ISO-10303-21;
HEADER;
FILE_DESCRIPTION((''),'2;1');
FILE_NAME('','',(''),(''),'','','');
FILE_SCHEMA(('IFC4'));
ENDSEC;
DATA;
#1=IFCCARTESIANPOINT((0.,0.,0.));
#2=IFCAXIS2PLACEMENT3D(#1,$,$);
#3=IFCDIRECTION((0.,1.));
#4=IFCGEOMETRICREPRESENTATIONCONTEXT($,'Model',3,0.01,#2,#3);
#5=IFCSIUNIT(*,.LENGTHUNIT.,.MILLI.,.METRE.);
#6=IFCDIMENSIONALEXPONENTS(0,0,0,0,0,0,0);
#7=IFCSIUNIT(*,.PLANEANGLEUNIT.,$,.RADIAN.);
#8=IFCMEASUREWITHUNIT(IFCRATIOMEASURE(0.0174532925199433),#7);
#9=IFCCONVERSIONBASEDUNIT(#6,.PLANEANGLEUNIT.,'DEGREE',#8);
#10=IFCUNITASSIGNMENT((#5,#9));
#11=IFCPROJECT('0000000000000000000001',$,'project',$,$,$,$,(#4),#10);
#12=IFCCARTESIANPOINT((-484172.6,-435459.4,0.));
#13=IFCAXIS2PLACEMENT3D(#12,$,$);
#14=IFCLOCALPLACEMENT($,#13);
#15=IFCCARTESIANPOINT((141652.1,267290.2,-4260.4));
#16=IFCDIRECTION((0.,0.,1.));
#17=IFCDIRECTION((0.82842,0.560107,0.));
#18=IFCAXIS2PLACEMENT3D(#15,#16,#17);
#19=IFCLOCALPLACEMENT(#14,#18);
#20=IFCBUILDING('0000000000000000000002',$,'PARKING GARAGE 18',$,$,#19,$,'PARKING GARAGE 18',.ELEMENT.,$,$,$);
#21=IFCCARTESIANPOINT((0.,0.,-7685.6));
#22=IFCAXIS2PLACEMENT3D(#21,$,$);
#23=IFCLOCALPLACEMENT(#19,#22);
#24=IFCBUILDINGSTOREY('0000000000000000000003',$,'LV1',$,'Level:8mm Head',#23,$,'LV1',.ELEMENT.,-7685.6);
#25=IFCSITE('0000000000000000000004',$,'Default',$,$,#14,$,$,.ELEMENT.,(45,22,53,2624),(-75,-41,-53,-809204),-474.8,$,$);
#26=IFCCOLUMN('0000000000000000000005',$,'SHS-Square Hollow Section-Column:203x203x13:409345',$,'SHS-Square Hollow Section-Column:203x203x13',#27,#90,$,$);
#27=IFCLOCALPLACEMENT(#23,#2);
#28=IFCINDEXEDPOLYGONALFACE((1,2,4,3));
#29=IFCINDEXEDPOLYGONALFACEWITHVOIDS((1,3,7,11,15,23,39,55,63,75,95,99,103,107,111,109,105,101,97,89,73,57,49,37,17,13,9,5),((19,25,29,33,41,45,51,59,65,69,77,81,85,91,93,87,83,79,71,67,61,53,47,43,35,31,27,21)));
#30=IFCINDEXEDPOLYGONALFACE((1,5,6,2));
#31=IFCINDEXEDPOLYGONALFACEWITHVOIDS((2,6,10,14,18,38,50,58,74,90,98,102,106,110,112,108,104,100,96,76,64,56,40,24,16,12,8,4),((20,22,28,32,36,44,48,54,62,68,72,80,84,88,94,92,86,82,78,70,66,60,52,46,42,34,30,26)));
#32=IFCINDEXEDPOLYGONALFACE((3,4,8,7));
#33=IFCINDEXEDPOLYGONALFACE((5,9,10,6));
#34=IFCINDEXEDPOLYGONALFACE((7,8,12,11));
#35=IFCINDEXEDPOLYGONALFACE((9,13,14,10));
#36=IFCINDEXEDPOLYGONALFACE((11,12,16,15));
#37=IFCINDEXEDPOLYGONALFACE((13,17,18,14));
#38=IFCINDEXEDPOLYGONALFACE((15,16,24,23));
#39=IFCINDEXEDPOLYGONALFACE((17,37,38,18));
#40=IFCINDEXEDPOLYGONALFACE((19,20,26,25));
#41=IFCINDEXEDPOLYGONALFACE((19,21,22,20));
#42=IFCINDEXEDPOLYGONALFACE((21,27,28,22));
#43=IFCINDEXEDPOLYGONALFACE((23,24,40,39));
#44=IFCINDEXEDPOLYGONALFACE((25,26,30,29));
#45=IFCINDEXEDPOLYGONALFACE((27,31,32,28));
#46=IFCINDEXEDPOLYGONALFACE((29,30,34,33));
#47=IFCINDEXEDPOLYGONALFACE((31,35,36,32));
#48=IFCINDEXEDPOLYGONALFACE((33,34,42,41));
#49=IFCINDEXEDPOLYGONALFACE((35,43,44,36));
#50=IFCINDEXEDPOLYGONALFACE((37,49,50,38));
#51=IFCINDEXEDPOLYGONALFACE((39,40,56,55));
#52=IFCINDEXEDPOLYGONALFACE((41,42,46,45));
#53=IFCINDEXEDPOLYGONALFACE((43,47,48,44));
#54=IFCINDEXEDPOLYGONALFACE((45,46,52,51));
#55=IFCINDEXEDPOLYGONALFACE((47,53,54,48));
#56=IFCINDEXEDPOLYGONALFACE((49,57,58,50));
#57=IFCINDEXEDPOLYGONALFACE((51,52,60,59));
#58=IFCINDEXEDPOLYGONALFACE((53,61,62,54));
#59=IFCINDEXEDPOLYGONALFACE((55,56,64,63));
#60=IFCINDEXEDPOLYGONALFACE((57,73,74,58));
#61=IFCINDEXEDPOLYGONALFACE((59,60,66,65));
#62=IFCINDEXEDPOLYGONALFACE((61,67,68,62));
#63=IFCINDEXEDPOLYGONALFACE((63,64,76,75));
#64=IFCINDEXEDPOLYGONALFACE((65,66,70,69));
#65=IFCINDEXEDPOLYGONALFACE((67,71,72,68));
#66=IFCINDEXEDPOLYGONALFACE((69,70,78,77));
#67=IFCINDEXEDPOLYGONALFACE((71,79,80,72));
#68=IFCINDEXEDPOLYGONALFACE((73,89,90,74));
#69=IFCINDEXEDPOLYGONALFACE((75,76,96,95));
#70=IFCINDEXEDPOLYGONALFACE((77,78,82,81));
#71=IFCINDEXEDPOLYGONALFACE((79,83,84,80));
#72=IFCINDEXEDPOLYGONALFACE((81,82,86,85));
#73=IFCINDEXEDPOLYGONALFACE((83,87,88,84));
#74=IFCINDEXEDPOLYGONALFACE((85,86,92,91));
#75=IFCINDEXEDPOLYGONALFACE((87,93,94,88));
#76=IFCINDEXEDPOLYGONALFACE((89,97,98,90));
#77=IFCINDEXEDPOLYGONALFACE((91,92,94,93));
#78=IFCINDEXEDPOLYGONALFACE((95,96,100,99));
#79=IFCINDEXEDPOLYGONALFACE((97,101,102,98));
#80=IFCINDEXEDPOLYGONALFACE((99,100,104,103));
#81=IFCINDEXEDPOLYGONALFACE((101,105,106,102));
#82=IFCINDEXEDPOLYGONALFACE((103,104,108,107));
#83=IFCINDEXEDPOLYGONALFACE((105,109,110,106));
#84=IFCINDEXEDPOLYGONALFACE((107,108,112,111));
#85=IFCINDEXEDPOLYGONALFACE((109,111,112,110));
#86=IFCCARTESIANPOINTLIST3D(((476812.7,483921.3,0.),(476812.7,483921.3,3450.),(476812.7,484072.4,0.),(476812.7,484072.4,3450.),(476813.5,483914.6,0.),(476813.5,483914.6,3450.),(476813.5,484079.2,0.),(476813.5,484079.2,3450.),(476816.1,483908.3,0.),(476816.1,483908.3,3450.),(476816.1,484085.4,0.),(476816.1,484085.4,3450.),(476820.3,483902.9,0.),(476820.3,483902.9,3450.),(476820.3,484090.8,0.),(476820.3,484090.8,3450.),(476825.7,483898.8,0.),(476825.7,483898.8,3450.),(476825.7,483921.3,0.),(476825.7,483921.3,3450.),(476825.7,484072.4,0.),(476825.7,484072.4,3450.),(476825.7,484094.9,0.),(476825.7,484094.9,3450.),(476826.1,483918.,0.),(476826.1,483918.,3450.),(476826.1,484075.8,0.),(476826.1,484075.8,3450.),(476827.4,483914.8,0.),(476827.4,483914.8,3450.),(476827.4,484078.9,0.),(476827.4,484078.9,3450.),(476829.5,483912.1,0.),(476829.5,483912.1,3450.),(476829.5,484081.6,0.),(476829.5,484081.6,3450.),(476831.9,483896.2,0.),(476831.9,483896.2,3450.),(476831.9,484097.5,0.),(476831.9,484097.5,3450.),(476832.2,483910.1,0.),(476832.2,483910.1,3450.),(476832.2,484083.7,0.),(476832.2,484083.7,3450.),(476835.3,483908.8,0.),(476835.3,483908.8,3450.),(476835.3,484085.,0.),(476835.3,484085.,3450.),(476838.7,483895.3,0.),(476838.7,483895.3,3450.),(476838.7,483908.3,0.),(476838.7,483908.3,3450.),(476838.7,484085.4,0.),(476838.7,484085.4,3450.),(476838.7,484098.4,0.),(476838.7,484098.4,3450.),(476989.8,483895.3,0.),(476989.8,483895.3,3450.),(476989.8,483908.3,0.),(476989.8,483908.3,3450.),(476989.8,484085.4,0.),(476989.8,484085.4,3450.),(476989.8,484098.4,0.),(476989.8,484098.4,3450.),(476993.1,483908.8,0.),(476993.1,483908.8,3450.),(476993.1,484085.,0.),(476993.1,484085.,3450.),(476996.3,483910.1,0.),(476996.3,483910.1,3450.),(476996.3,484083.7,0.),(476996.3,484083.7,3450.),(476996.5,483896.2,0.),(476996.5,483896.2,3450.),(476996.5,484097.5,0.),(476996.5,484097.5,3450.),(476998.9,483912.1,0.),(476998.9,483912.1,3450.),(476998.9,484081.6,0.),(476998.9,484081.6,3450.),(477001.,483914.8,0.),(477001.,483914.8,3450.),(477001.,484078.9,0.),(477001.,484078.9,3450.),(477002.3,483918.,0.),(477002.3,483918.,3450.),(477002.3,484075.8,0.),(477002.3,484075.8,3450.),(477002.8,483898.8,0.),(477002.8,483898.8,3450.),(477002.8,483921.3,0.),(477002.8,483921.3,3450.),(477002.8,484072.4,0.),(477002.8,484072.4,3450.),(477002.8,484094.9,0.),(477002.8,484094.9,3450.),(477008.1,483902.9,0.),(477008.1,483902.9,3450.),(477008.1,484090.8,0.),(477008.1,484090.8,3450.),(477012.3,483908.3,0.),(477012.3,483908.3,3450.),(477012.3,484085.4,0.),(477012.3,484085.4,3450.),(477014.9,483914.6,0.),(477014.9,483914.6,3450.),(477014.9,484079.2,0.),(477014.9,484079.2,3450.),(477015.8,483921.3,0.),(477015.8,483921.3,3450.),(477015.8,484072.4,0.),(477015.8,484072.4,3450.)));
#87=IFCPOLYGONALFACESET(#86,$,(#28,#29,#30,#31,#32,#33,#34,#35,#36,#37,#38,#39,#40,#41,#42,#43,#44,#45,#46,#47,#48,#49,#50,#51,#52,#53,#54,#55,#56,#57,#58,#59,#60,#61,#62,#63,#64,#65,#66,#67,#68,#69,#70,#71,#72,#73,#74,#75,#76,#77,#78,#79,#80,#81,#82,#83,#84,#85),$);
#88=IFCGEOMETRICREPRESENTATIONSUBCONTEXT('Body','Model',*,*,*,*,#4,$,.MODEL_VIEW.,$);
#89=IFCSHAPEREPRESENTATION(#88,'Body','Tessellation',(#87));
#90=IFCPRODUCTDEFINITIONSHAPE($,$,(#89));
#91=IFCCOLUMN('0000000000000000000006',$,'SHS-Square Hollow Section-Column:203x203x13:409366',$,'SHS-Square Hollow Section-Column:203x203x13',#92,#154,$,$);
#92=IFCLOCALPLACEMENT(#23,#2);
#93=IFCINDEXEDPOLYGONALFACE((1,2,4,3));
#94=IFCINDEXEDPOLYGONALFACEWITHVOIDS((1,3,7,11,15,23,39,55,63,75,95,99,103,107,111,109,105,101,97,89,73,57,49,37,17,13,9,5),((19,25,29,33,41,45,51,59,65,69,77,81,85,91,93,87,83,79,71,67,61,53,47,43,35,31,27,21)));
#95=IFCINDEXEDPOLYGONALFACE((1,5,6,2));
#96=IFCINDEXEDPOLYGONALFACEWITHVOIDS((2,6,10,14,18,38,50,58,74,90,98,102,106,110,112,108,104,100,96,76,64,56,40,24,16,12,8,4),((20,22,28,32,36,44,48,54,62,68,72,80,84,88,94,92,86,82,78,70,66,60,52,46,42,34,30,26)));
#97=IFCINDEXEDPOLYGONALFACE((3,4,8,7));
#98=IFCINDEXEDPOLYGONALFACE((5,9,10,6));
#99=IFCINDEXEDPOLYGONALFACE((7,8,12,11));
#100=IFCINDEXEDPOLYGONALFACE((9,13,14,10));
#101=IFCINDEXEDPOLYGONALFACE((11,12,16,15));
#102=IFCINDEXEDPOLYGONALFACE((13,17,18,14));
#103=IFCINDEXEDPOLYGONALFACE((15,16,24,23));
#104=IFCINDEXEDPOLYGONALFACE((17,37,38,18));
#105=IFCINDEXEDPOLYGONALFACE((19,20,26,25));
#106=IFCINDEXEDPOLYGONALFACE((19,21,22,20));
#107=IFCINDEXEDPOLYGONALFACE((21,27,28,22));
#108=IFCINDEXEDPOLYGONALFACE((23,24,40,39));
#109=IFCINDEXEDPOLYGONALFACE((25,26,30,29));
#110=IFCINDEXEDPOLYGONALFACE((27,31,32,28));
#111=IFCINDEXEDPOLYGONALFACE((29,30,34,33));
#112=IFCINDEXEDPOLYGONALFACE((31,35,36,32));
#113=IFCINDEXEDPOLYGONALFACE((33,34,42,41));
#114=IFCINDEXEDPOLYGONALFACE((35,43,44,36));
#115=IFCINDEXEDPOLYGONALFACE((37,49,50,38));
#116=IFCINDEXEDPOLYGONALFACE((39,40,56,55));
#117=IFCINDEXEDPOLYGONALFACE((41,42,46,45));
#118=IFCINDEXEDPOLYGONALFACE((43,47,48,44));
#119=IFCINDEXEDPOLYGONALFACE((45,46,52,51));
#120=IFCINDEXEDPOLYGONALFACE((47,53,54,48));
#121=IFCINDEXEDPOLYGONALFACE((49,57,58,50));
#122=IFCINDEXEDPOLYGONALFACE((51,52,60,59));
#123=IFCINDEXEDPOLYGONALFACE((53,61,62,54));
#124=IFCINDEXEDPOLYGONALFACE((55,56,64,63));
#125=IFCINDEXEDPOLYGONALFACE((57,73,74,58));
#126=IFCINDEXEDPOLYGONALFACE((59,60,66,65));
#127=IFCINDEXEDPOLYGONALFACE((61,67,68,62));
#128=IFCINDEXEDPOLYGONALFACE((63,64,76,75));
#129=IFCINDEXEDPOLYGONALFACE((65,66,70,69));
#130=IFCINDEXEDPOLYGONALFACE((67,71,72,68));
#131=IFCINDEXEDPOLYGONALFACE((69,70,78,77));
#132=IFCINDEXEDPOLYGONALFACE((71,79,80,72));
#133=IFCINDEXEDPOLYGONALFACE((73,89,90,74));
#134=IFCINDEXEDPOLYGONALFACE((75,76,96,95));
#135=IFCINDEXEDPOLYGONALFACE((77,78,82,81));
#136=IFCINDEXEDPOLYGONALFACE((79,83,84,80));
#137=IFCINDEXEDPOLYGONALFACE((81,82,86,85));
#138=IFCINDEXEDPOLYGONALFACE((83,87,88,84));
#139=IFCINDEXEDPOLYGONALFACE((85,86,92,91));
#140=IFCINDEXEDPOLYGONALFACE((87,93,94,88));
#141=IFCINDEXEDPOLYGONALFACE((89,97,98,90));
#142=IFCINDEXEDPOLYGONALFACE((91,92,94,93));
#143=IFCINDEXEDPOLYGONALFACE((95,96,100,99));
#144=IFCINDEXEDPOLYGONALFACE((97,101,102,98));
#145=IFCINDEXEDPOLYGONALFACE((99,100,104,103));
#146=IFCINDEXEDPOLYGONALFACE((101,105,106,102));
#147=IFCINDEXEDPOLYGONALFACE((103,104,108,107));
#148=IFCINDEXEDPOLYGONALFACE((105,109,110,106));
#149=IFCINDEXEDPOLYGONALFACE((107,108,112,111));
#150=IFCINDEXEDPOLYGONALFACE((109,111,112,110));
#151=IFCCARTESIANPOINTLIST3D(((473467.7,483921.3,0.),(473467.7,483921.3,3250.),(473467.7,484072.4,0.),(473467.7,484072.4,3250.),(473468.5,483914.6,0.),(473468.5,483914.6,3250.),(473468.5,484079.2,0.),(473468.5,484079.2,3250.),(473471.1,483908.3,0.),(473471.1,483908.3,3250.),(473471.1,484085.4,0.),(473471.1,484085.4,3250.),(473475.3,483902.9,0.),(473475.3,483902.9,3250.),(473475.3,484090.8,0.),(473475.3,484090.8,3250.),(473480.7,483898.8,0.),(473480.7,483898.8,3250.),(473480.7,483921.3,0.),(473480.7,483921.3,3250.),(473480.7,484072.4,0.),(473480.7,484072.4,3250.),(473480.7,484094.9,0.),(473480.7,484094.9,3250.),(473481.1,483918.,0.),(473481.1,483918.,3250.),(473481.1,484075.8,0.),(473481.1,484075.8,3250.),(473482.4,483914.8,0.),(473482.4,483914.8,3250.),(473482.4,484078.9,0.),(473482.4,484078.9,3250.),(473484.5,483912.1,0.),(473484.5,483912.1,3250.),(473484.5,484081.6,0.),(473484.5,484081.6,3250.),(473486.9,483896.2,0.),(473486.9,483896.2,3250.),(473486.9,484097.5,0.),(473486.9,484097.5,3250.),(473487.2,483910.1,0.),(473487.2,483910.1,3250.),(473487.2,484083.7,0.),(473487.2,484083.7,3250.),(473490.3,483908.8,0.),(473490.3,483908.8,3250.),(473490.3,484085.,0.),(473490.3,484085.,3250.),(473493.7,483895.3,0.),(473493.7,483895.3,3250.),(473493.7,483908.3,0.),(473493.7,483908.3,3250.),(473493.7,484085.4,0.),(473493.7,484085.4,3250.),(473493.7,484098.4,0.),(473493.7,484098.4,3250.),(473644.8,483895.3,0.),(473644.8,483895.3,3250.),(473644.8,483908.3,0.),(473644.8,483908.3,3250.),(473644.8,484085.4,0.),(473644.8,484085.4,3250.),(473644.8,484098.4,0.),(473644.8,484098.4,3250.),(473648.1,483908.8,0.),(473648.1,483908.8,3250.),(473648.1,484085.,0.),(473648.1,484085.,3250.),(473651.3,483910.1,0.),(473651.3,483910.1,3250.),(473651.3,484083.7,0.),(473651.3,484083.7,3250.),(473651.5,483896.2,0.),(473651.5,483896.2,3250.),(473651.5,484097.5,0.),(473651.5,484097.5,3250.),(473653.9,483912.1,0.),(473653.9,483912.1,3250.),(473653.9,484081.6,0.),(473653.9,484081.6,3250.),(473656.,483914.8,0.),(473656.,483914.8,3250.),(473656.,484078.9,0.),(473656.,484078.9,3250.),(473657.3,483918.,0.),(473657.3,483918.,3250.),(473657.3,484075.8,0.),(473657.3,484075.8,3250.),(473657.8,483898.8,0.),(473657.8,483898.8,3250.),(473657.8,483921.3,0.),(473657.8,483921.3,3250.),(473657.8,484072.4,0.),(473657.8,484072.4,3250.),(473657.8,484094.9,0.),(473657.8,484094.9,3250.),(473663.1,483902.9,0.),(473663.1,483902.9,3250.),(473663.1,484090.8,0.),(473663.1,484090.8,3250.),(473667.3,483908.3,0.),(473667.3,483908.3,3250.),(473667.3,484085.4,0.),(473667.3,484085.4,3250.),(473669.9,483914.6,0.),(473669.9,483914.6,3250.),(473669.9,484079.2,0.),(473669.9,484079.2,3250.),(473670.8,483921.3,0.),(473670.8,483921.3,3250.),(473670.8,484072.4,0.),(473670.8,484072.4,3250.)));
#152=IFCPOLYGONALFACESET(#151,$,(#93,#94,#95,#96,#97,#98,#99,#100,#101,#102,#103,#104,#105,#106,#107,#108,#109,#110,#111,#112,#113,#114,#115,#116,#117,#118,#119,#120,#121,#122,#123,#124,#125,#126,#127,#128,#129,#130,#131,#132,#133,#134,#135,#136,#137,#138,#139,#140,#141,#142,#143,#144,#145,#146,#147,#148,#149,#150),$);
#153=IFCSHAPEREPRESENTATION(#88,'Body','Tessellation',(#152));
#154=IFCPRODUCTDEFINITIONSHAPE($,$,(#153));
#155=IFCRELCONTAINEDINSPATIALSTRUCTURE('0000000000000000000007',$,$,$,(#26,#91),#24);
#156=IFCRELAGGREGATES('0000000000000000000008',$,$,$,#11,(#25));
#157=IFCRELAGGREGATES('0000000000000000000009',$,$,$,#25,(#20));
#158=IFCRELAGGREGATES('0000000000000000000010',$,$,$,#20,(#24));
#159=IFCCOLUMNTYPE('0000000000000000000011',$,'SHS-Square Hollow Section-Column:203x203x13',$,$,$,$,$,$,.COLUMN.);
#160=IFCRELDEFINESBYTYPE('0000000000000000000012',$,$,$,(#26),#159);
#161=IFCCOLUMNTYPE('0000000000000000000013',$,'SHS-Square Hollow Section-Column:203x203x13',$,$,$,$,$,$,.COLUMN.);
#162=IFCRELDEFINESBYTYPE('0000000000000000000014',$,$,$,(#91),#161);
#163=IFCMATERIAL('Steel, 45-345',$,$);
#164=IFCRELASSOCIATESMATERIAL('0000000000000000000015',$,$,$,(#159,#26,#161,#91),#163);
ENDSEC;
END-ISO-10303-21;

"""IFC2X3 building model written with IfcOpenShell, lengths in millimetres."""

from ifc_helpers import new_model, entity, si_unit, converted_unit, direction, frame, frame_2d, origin, place, context, subcontext, project, spatial, polyline, circle_curve, parameter, trimmed, segment, composite_curve, outline, extrude, source, transform, mapped, material, type_object, type_shapes, element, save


model = new_model("IFC2X3")

# Units and contexts
model_context = context("Model", 3, precision=0.01, world=origin(), true_north=direction((0.0, 1.0)))
body_context = subcontext(model_context, "Body", "Model", "MODEL_VIEW")
ifc_project = project(units=[si_unit("LENGTHUNIT", "METRE", prefix="MILLI"), converted_unit("PLANEANGLEUNIT", "DEGREE", entity("IfcRatioMeasure", 0.0174532925199433), si_unit("PLANEANGLEUNIT", "RADIAN"), dimensions=[0, 0, 0, 0, 0, 0, 0])], contexts=[model_context])

# Site, building, storey
site_placement = place(None, frame((-484172.6, -435459.4, 0.0)))
site = spatial("IfcSite", under=ifc_project, at=site_placement, Name="Default", CompositionType="ELEMENT", RefLatitude=(45, 22, 53, 2624), RefLongitude=(-75, -41, -53, -809204), RefElevation=-474.8)
building_placement = place(site_placement, frame((141652.1, 267290.2, -4260.4), z_axis=(0.0, 0.0, 1.0), x_axis=(0.82842, 0.560107, 0.0)))
building = spatial("IfcBuilding", under=site, at=building_placement, Name="PARKING GARAGE 18", LongName="PARKING GARAGE 18", CompositionType="ELEMENT")
storey_placement = place(building_placement, frame((0.0, 0.0, -7685.6)))
storey = spatial("IfcBuildingStorey", under=building, at=storey_placement, Name="LV1", ObjectType="Level:8mm Head", LongName="LV1", CompositionType="ELEMENT", Elevation=-7685.6)

# Columns
ifc_material_1 = material(Name="Steel, 45-345")
column_type_1 = type_object("IfcColumnType", Name="SHS-Square Hollow Section-Column:203x203x13", PredefinedType="COLUMN", material=ifc_material_1)
shared_shape_1 = source(origin(), body_context, "Body", "SweptSolid", [
    extrude(outline(composite_curve([segment(polyline([(-75.6, -101.5), (75.6, -101.5)]), True, "CONTINUOUS"), segment(trimmed(circle_curve(frame_2d((75.6, -75.6), x_axis=(-1.0, 0.0)), 26.0), [parameter(90.0)], [parameter(180.0)], True, "PARAMETER"), True, "CONTINUOUS"), segment(polyline([(101.5, -75.6), (101.5, 75.6)]), True, "CONTINUOUS"), segment(trimmed(circle_curve(frame_2d((75.5, 75.6), x_axis=(-1.0, 0.0)), 26.0), [parameter(180.0)], [parameter(270.0)], True, "PARAMETER"), True, "CONTINUOUS"), segment(polyline([(75.5, 101.6), (-75.5, 101.6)]), True, "CONTINUOUS"), segment(trimmed(circle_curve(frame_2d((-75.5, 75.5), x_axis=(-1.0, 0.0)), 26.0), [parameter(270.0)], [parameter(360.0)], True, "PARAMETER"), True, "CONTINUOUS"), segment(polyline([(-101.5, 75.5), (-101.5, -75.6)]), True, "CONTINUOUS"), segment(trimmed(circle_curve(frame_2d((-75.6, -75.6), x_axis=(-1.0, 0.0)), 26.0), [parameter(360.0)], [parameter(90.0)], True, "PARAMETER"), True, "CONTINUOUS")], self_intersect=False), holes=[composite_curve([segment(trimmed(circle_curve(frame_2d((-75.6, -75.6), x_axis=(-1.0, 0.0)), 13.0), [parameter(0.0)], [parameter(90.0)], True, "PARAMETER"), False, "CONTINUOUS"), segment(polyline([(-88.5, -75.6), (-88.5, 75.6)]), True, "CONTINUOUS"), segment(trimmed(circle_curve(frame_2d((-75.6, 75.6), x_axis=(-1.0, 0.0)), 13.0), [parameter(270.0)], [parameter(0.0)], True, "PARAMETER"), False, "CONTINUOUS"), segment(polyline([(-75.6, 88.6), (75.5, 88.6)]), True, "CONTINUOUS"), segment(trimmed(circle_curve(frame_2d((75.5, 75.5), x_axis=(-1.0, 0.0)), 13.0), [parameter(180.0)], [parameter(270.0)], True, "PARAMETER"), False, "CONTINUOUS"), segment(polyline([(88.6, 75.5), (88.6, -75.5)]), True, "CONTINUOUS"), segment(trimmed(circle_curve(frame_2d((75.6, -75.5), x_axis=(-1.0, 0.0)), 13.0), [parameter(90.0)], [parameter(180.0)], True, "PARAMETER"), False, "CONTINUOUS"), segment(polyline([(75.6, -88.5), (-75.6, -88.5)]), True, "CONTINUOUS")], self_intersect=False)]), frame((0.0, 0.0, -7685.6), z_axis=(0.0, 0.0, 1.0), x_axis=(-1.0, 0.0, 0.0)), (0.0, 0.0, 1.0), 3450.0),
])
type_shapes(column_type_1, [shared_shape_1])
for number, where, name in (
    (1, (476914.2, 483996.9, 7685.6), "SHS-Square Hollow Section-Column:203x203x13:409345"),
):
    element("IfcColumn", number, at=place(storey_placement, frame(where)), inside=storey, type_object=column_type_1, material=ifc_material_1, Name=name, ObjectType="SHS-Square Hollow Section-Column:203x203x13", context=body_context, shape_type="MappedRepresentation", body=[
        mapped(shared_shape_1, transform((0.0, 0.0, 0.0), scale=1.0)),
    ])
column_type_2 = type_object("IfcColumnType", Name="SHS-Square Hollow Section-Column:203x203x13", PredefinedType="COLUMN", material=ifc_material_1)
shared_shape_2 = source(origin(), body_context, "Body", "SweptSolid", [
    extrude(outline(composite_curve([segment(polyline([(-75.6, -101.5), (75.6, -101.5)]), True, "CONTINUOUS"), segment(trimmed(circle_curve(frame_2d((75.6, -75.6), x_axis=(-1.0, 0.0)), 26.0), [parameter(90.0)], [parameter(180.0)], True, "PARAMETER"), True, "CONTINUOUS"), segment(polyline([(101.5, -75.6), (101.5, 75.6)]), True, "CONTINUOUS"), segment(trimmed(circle_curve(frame_2d((75.5, 75.6), x_axis=(-1.0, 0.0)), 26.0), [parameter(180.0)], [parameter(270.0)], True, "PARAMETER"), True, "CONTINUOUS"), segment(polyline([(75.5, 101.6), (-75.5, 101.6)]), True, "CONTINUOUS"), segment(trimmed(circle_curve(frame_2d((-75.5, 75.5), x_axis=(-1.0, 0.0)), 26.0), [parameter(270.0)], [parameter(360.0)], True, "PARAMETER"), True, "CONTINUOUS"), segment(polyline([(-101.5, 75.5), (-101.5, -75.6)]), True, "CONTINUOUS"), segment(trimmed(circle_curve(frame_2d((-75.6, -75.6), x_axis=(-1.0, 0.0)), 26.0), [parameter(360.0)], [parameter(90.0)], True, "PARAMETER"), True, "CONTINUOUS")], self_intersect=False), holes=[composite_curve([segment(trimmed(circle_curve(frame_2d((-75.6, -75.6), x_axis=(-1.0, 0.0)), 13.0), [parameter(0.0)], [parameter(90.0)], True, "PARAMETER"), False, "CONTINUOUS"), segment(polyline([(-88.5, -75.6), (-88.5, 75.6)]), True, "CONTINUOUS"), segment(trimmed(circle_curve(frame_2d((-75.6, 75.6), x_axis=(-1.0, 0.0)), 13.0), [parameter(270.0)], [parameter(0.0)], True, "PARAMETER"), False, "CONTINUOUS"), segment(polyline([(-75.6, 88.6), (75.5, 88.6)]), True, "CONTINUOUS"), segment(trimmed(circle_curve(frame_2d((75.5, 75.5), x_axis=(-1.0, 0.0)), 13.0), [parameter(180.0)], [parameter(270.0)], True, "PARAMETER"), False, "CONTINUOUS"), segment(polyline([(88.6, 75.5), (88.6, -75.5)]), True, "CONTINUOUS"), segment(trimmed(circle_curve(frame_2d((75.6, -75.5), x_axis=(-1.0, 0.0)), 13.0), [parameter(90.0)], [parameter(180.0)], True, "PARAMETER"), False, "CONTINUOUS"), segment(polyline([(75.6, -88.5), (-75.6, -88.5)]), True, "CONTINUOUS")], self_intersect=False)]), frame((0.0, 0.0, -7685.6), z_axis=(0.0, 0.0, 1.0), x_axis=(-1.0, 0.0, 0.0)), (0.0, 0.0, 1.0), 3250.0),
])
type_shapes(column_type_2, [shared_shape_2])
column_placement = place(storey_placement, frame((473569.2, 483996.9, 7685.6)))
element("IfcColumn", 2, at=column_placement, inside=storey, type_object=column_type_2, material=ifc_material_1, Name="SHS-Square Hollow Section-Column:203x203x13:409366", ObjectType="SHS-Square Hollow Section-Column:203x203x13", context=body_context, shape_type="MappedRepresentation", body=[
    mapped(shared_shape_2, transform((0.0, 0.0, 0.0), scale=1.0)),
])

save(model, "model.ifc")
